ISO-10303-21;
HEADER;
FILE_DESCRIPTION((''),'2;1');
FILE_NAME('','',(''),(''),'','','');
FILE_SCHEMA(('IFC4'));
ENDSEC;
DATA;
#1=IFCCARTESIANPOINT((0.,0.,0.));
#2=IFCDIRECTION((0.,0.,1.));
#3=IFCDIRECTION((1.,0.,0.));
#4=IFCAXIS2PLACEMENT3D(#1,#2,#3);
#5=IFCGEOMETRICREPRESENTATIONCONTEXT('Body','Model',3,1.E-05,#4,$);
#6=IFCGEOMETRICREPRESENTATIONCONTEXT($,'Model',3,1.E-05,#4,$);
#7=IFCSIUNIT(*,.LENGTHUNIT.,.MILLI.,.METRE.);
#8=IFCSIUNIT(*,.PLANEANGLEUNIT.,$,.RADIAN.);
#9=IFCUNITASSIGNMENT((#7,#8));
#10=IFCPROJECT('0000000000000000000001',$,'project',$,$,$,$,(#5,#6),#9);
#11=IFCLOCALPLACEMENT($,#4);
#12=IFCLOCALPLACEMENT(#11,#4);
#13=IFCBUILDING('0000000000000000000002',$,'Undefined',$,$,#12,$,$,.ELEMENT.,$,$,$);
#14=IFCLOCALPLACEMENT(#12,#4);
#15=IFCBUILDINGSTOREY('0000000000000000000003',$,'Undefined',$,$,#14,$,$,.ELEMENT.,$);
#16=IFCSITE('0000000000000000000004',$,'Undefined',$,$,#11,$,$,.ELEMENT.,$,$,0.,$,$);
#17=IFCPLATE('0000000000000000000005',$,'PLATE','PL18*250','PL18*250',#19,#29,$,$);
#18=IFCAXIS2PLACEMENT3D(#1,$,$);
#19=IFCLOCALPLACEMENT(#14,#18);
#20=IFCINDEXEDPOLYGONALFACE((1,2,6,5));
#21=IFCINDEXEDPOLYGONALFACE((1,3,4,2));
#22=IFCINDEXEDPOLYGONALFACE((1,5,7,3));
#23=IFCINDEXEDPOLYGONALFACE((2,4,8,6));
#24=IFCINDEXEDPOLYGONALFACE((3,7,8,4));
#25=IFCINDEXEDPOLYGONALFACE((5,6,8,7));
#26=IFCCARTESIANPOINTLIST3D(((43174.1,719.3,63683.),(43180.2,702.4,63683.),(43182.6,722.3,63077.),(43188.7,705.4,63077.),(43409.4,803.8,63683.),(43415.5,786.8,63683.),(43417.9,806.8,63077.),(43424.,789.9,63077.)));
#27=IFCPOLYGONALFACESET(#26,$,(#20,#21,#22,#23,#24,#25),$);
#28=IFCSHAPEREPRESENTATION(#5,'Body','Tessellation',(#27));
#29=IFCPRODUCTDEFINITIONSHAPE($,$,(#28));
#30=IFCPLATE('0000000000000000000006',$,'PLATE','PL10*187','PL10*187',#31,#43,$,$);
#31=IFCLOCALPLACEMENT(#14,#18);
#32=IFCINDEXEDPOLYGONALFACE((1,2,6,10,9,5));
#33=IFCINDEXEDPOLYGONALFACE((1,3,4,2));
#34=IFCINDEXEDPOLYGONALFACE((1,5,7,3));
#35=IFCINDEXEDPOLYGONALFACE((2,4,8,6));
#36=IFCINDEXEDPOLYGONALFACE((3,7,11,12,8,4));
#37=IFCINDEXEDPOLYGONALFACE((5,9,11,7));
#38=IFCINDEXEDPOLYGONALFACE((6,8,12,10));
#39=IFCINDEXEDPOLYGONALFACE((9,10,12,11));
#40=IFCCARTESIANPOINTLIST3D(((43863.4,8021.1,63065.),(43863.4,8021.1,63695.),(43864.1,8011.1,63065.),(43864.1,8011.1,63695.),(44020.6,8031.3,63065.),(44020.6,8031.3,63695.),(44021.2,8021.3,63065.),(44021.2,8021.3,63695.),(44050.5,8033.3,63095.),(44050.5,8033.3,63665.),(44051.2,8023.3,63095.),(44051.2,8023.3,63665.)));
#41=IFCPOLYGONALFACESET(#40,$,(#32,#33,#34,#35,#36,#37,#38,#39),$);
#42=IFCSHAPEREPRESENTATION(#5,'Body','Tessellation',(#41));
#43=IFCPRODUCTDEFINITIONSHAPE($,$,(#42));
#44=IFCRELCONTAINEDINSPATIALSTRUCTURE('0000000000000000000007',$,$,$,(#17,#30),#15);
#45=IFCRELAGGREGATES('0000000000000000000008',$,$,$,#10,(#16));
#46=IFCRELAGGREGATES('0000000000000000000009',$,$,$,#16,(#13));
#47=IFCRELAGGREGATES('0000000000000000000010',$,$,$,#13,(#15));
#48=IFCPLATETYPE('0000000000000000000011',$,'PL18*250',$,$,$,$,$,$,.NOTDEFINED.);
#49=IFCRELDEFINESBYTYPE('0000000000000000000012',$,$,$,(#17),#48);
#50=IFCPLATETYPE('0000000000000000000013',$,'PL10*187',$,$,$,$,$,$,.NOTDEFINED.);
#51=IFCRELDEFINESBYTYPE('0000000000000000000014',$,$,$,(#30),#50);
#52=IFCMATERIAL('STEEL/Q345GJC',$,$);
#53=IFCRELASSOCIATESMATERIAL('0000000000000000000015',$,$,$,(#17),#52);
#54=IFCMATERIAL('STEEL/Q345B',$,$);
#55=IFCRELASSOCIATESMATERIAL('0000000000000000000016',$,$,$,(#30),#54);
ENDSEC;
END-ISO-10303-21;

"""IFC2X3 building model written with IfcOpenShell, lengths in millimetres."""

from ifc_helpers import new_model, si_unit, frame, origin_with_axes, place, context, project, spatial, polyline, outline, extrude, material, type_object, element, save


model = new_model("IFC2X3")

# Units and contexts
model_context_1 = context("Model", 3, precision=1e-05, world=origin_with_axes(), identifier="Body")
model_context_2 = context("Model", 3, precision=1e-05, world=origin_with_axes())
ifc_project = project(units=[si_unit("LENGTHUNIT", "METRE", prefix="MILLI"), si_unit("PLANEANGLEUNIT", "RADIAN")], contexts=[model_context_1, model_context_2])

# Site, building, storey
site_placement = place(None, origin_with_axes())
site = spatial("IfcSite", under=ifc_project, at=site_placement, Name="Undefined", CompositionType="ELEMENT", RefElevation=0.0)
building_placement = place(site_placement, origin_with_axes())
building = spatial("IfcBuilding", under=site, at=building_placement, Name="Undefined", CompositionType="ELEMENT")
storey_placement = place(building_placement, origin_with_axes())
storey = spatial("IfcBuildingStorey", under=building, at=storey_placement, Name="Undefined", CompositionType="ELEMENT")

# Shared definitions
ifc_material_1 = material(Name="STEEL/Q345B")
ifc_material_2 = material(Name="STEEL/Q345GJC")

# Plates
plate_type_1 = type_object("IfcPlateType", Name="PL18*250", PredefinedType="NOTDEFINED")
plate_1_placement = place(storey_placement, frame((43177.1, 710.8, 63683.0), z_axis=(-0.337816, 0.941212, 0.0), x_axis=(0.941212, 0.337816, 0.0)))
element("IfcPlate", 1, at=plate_1_placement, inside=storey, type_object=plate_type_1, material=ifc_material_2, Name="PLATE", Description="PL18*250", ObjectType="PL18*250", context=model_context_1, shape_type="SweptSolid", body=[
    extrude(outline(polyline([(0.0, 0.0), (250.0, 0.0), (259.0, 606.0), (9.0, 606.0), (0.0, 0.0)])), frame((0.0, 0.0, -9.0), z_axis=(0.0, 0.0, 1.0), x_axis=(1.0, 0.0, 0.0)), (0.0, 0.0, 1.0), 18.0),
])
plate_type_2 = type_object("IfcPlateType", Name="PL10*187", PredefinedType="NOTDEFINED")
plate_2_placement = place(storey_placement, frame((44050.8, 8028.3, 63065.0), z_axis=(-0.065184, 0.997873, 0.0), x_axis=(-0.997873, -0.065183, 0.0)))
element("IfcPlate", 2, at=plate_2_placement, inside=storey, type_object=plate_type_2, material=ifc_material_1, Name="PLATE", Description="PL10*187", ObjectType="PL10*187", context=model_context_1, shape_type="SweptSolid", body=[
    extrude(outline(polyline([(0.0, 30.0), (30.0, 0.0), (187.5, 0.0), (187.5, 630.0), (30.0, 630.0), (0.0, 600.0), (0.0, 30.0)])), frame((0.0, 0.0, -5.0), z_axis=(0.0, 0.0, 1.0), x_axis=(1.0, 0.0, 0.0)), (0.0, 0.0, 1.0), 10.0),
])

save(model, "model.ifc")
